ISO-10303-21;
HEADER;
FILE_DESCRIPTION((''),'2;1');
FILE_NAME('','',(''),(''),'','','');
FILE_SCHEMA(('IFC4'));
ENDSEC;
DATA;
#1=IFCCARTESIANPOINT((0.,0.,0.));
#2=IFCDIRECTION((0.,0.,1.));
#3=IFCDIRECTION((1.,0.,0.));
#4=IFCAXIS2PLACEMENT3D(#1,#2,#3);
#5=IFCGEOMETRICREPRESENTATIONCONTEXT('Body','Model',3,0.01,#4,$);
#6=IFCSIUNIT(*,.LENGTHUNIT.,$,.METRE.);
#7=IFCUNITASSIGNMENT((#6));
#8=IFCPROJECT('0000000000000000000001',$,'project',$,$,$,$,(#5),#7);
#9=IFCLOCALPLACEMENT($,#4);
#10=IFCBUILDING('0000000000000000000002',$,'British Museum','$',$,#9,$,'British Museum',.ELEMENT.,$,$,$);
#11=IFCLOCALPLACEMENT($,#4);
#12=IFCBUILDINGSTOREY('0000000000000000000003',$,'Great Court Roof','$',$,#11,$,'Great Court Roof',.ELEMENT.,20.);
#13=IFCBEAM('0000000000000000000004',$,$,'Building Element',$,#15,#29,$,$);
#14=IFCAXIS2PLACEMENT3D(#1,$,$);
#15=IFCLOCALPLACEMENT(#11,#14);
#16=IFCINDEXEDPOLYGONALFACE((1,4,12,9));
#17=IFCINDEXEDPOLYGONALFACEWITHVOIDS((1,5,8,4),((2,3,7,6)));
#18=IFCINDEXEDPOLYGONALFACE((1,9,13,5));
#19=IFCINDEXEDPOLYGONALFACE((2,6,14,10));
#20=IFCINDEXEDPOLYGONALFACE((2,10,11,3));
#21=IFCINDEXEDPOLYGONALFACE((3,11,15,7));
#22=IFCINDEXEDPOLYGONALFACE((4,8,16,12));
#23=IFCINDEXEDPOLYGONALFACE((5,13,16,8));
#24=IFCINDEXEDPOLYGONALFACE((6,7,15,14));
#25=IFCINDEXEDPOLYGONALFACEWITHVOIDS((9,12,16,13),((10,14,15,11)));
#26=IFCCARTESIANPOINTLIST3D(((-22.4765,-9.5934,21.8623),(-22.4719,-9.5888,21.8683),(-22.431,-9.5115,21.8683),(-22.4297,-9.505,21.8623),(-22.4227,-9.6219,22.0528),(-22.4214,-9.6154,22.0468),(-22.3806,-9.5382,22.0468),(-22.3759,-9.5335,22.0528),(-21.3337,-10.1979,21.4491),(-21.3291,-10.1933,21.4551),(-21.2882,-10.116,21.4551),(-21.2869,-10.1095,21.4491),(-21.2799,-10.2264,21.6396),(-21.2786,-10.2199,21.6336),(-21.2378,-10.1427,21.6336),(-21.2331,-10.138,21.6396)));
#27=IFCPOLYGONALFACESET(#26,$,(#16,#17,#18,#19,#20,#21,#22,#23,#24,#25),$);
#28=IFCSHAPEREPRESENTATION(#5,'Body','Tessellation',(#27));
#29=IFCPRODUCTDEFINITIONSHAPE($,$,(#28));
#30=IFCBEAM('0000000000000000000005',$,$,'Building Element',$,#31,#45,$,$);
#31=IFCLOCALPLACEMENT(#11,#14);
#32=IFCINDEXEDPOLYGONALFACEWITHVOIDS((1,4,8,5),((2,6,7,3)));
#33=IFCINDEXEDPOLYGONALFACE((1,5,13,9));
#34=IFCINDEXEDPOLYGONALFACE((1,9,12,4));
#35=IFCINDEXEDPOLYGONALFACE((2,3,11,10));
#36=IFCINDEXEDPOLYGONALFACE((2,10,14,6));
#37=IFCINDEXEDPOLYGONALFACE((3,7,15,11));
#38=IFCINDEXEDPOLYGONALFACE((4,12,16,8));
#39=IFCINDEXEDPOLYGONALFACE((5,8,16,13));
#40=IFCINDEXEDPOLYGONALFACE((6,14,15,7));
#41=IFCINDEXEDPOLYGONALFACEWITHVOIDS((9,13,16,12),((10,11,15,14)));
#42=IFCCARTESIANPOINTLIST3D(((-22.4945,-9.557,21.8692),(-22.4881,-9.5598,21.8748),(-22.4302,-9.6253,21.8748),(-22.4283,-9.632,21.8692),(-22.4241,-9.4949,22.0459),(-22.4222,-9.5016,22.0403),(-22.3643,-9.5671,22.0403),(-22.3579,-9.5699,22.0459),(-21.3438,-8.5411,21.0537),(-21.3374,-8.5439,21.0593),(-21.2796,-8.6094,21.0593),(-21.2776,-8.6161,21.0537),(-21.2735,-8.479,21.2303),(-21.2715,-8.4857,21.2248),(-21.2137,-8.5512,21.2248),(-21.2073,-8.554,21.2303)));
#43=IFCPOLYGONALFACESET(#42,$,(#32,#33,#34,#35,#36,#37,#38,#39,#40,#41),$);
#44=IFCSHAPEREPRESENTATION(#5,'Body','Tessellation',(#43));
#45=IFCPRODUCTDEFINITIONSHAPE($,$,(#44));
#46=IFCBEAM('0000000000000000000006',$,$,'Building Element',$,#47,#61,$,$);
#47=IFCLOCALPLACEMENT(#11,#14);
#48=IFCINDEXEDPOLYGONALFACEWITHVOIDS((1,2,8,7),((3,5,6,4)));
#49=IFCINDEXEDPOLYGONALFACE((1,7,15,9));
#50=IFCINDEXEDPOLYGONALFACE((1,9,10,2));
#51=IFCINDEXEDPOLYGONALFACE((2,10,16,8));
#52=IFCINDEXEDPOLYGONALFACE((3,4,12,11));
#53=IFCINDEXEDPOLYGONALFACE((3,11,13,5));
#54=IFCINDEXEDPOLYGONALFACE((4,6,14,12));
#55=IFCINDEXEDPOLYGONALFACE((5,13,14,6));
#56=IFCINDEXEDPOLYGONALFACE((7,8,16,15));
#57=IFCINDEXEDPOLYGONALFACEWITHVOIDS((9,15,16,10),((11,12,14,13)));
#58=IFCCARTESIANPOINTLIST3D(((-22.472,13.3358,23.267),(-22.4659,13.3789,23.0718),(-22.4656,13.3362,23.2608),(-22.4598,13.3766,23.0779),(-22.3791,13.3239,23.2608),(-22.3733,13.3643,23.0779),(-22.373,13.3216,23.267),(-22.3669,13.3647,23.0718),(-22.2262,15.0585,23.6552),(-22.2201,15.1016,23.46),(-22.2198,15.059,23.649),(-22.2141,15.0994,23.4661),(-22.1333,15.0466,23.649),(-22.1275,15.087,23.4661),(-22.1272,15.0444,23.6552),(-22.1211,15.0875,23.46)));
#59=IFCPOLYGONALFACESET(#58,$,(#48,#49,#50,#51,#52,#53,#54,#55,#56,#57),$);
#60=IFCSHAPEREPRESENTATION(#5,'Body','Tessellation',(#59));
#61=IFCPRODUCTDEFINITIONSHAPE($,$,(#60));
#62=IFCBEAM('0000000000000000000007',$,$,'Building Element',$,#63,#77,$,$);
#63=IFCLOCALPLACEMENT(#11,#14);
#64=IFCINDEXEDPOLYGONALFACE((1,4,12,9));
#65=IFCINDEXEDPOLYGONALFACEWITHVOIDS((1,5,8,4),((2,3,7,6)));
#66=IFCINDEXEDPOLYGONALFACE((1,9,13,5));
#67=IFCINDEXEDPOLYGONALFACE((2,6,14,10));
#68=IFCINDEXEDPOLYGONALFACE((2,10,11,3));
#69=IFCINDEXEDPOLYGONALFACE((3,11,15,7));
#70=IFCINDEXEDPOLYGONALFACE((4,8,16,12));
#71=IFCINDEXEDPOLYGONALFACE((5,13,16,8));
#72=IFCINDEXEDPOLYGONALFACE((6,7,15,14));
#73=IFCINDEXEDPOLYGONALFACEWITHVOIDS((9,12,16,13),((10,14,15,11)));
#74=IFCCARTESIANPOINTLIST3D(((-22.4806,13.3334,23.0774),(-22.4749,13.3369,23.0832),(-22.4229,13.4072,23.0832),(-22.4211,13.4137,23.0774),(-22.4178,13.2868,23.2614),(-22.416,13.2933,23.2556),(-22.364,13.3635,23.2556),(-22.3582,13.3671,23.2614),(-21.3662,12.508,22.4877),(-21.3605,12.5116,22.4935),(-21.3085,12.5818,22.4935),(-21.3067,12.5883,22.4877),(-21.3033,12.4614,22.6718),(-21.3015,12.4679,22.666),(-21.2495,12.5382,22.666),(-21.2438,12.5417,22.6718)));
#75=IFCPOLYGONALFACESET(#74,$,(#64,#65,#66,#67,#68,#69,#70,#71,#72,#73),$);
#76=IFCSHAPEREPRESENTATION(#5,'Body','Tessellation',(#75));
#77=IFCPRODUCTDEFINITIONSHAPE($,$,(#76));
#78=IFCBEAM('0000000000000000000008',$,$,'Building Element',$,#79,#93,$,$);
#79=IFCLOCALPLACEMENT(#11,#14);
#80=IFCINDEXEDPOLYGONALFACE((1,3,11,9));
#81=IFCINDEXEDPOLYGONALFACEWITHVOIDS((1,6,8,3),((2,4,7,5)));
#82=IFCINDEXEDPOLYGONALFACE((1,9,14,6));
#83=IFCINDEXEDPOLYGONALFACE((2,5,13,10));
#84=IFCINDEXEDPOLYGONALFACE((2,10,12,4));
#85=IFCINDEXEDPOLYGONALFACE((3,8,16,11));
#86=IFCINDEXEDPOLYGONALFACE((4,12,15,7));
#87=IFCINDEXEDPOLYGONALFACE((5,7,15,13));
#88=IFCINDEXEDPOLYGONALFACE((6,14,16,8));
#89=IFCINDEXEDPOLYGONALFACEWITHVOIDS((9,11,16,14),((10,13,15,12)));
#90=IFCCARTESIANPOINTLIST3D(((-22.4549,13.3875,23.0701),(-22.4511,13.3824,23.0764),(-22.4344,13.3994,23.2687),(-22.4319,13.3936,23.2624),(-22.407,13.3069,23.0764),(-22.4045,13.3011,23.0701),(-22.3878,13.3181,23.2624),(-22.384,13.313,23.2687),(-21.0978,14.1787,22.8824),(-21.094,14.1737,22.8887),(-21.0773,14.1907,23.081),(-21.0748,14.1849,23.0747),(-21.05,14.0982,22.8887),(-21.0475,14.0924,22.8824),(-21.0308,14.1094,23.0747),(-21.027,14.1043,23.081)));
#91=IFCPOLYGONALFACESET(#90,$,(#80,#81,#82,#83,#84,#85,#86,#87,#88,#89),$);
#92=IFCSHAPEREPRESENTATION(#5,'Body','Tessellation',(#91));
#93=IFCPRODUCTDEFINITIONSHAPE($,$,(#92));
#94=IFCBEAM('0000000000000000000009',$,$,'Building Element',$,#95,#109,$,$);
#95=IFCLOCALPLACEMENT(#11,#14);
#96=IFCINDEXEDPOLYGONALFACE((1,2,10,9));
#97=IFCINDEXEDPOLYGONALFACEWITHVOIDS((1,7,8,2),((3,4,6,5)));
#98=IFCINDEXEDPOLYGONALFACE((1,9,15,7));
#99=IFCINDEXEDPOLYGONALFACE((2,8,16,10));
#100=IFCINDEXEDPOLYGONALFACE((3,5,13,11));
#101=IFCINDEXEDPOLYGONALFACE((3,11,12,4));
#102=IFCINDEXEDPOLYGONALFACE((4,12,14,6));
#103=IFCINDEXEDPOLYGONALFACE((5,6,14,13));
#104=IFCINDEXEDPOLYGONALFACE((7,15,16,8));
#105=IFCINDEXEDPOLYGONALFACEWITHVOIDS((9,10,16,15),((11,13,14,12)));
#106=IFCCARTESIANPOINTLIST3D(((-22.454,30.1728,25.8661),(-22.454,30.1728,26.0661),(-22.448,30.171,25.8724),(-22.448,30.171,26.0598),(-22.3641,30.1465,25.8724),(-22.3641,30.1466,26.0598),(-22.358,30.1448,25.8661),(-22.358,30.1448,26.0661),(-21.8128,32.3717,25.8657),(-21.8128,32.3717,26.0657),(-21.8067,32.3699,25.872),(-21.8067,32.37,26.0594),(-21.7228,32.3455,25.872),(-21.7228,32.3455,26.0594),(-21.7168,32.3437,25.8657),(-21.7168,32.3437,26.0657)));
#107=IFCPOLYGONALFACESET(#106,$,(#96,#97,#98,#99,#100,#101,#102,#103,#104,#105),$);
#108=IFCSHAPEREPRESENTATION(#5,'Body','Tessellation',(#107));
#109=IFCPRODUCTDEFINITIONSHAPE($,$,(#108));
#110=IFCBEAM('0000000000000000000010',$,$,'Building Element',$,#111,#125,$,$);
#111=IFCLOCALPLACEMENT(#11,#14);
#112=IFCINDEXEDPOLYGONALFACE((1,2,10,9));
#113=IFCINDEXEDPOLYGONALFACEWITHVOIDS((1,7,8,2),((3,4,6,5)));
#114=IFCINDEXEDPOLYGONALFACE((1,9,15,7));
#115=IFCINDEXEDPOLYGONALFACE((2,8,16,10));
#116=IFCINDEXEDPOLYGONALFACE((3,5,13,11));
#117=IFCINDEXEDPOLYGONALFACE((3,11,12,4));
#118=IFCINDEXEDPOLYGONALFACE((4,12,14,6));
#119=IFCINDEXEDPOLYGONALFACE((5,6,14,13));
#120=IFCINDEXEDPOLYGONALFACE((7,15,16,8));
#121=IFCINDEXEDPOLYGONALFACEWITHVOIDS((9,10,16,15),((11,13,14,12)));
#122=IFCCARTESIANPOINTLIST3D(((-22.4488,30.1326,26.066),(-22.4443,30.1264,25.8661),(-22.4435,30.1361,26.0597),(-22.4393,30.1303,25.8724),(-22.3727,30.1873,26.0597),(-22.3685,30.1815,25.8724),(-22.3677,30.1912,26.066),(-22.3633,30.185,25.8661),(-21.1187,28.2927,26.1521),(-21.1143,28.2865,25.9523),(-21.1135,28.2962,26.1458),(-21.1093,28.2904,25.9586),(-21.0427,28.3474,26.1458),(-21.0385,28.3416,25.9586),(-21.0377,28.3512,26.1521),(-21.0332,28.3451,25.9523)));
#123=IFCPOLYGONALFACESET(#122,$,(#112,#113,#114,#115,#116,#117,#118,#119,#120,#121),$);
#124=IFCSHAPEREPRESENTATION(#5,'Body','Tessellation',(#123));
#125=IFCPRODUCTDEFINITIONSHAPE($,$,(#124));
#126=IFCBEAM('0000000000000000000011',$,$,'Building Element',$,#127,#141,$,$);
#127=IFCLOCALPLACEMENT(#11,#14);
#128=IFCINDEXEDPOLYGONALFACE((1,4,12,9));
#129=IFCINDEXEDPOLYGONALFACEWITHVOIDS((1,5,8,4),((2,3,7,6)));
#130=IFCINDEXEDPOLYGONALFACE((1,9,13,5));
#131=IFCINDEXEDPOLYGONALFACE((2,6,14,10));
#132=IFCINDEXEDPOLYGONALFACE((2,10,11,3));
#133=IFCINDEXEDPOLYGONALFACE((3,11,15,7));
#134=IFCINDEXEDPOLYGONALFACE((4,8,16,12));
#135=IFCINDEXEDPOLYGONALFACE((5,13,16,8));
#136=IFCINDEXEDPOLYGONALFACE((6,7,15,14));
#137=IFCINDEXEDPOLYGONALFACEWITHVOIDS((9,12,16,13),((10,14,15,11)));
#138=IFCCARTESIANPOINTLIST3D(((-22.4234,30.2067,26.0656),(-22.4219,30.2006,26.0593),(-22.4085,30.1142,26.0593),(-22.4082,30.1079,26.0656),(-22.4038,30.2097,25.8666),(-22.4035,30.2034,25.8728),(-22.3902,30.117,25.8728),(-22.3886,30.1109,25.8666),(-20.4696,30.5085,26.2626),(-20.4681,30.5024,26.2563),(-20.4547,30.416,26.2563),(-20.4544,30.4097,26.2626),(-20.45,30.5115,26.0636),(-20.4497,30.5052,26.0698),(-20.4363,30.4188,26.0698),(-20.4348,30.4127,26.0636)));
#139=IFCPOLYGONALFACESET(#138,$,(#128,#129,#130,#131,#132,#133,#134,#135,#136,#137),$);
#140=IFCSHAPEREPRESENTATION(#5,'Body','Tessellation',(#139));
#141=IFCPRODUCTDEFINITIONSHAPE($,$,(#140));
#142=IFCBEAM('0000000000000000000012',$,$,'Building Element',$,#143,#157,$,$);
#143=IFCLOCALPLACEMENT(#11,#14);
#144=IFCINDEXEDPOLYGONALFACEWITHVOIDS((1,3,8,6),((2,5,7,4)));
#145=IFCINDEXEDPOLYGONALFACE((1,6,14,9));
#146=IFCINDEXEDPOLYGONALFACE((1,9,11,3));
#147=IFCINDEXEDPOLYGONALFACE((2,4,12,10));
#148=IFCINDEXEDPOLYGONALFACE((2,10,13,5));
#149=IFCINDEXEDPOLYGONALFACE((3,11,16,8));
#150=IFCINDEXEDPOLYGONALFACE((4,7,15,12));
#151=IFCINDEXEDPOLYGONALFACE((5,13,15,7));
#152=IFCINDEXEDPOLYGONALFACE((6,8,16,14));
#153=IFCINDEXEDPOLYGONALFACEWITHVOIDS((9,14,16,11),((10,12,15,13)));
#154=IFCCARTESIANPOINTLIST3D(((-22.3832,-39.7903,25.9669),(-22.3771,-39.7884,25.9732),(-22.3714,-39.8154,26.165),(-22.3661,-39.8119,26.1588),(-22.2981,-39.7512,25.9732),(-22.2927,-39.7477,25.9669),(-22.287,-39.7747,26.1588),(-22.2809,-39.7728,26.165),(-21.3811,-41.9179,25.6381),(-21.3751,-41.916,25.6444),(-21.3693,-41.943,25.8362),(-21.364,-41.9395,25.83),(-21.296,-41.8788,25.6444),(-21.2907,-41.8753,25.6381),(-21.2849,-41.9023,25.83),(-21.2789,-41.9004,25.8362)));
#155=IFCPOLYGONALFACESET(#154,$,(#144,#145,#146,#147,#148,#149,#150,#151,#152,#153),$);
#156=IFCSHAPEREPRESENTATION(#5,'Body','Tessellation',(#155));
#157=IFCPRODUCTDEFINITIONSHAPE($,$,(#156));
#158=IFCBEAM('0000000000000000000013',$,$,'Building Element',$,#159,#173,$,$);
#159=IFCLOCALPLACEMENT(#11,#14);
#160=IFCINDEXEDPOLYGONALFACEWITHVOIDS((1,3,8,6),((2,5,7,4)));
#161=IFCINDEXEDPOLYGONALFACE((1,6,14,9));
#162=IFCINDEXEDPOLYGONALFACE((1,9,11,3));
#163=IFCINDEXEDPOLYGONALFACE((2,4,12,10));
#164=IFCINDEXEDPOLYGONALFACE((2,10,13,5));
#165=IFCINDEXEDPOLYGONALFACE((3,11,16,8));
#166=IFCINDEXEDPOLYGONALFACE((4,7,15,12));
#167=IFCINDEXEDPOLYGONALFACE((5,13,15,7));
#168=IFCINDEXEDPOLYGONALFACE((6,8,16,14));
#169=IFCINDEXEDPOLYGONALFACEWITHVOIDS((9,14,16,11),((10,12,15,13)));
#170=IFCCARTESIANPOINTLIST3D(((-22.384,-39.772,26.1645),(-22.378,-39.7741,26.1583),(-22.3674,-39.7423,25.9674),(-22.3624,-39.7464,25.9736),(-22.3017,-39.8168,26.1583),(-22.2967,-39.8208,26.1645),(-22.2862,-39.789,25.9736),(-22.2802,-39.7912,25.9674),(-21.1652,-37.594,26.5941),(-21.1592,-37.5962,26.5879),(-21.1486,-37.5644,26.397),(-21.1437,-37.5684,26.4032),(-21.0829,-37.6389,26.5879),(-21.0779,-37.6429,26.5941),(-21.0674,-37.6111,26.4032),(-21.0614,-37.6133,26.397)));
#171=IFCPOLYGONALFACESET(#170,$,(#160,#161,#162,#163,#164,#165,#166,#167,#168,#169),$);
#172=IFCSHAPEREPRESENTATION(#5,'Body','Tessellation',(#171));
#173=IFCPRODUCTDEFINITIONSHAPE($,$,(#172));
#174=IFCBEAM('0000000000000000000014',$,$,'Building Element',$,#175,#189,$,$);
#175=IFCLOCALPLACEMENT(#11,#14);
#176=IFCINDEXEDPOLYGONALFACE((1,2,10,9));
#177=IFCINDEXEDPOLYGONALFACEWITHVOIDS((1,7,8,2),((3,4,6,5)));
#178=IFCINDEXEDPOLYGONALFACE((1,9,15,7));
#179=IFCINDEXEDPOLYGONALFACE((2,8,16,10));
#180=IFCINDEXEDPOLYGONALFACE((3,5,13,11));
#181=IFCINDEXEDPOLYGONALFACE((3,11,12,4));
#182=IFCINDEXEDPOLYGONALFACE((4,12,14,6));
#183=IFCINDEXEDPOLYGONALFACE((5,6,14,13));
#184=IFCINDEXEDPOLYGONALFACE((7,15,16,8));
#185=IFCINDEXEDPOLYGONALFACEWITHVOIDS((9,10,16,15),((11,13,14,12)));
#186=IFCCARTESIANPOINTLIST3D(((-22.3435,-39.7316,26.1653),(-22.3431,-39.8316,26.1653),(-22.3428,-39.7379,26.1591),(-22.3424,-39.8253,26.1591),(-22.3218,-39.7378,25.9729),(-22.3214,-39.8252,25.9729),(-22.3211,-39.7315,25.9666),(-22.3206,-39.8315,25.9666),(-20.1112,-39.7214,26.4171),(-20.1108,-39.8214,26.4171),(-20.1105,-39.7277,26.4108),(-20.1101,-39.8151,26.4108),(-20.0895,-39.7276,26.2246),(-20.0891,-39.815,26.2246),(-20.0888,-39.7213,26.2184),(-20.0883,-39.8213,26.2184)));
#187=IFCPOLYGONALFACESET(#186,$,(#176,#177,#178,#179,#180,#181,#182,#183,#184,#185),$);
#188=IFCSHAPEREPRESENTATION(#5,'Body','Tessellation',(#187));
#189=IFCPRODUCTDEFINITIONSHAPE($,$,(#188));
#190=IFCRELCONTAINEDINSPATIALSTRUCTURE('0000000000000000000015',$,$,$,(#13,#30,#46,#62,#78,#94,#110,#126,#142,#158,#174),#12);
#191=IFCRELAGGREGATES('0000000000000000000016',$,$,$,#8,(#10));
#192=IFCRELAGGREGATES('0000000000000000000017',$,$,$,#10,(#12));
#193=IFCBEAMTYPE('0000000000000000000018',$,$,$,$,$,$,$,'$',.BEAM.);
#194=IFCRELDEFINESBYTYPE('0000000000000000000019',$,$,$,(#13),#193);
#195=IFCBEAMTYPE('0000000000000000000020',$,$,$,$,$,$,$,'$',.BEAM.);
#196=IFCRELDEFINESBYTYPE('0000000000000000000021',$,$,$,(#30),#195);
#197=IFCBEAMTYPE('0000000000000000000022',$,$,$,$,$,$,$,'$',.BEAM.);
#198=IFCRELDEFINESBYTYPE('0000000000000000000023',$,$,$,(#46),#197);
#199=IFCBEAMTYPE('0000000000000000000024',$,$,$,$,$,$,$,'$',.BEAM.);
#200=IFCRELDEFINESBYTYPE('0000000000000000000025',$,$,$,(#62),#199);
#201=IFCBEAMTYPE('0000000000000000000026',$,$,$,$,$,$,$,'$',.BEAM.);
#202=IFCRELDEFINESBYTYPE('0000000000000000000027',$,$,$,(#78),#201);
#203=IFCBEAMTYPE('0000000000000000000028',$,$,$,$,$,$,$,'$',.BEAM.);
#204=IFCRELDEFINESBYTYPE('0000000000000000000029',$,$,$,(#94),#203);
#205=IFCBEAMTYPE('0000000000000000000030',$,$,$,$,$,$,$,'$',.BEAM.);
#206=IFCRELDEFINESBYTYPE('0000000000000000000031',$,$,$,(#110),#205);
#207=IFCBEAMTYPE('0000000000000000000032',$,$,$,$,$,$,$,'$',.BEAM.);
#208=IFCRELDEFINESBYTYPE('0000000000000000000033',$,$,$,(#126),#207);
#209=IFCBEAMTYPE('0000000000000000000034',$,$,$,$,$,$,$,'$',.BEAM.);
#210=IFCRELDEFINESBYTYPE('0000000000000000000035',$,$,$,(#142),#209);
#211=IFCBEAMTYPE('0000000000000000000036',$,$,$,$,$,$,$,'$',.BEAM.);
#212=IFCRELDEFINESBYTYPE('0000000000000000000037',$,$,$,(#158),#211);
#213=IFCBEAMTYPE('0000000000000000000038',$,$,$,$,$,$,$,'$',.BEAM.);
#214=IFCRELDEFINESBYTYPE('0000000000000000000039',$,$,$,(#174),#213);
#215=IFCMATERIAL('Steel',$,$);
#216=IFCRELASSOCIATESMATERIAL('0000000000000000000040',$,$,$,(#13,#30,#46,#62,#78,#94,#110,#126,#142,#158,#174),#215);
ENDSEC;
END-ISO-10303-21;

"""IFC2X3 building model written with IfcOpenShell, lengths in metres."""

from ifc_helpers import new_model, si_unit, frame, origin_with_axes, origin_2d, place, context, project, spatial, hollow_rectangle, extrude, material, type_object, element, save


model = new_model("IFC2X3")

# Units and contexts
model_context = context("Model", 3, precision=0.01, world=origin_with_axes(), identifier="Body")
ifc_project = project(units=[si_unit("LENGTHUNIT", "METRE")], contexts=[model_context])

# Building, storey
building_placement = place(None, origin_with_axes())
building = spatial("IfcBuilding", under=ifc_project, at=building_placement, Name="British Museum", Description="$", LongName="British Museum", CompositionType="ELEMENT")
storey_placement = place(None, origin_with_axes())
storey = spatial("IfcBuildingStorey", under=building, at=storey_placement, Name="Great Court Roof", Description="$", LongName="Great Court Roof", CompositionType="ELEMENT", Elevation=20.0)

# Beams
ifc_material = material(Name="Steel")
beam_type_1 = type_object("IfcBeamType", ElementType="$", PredefinedType="BEAM")
beam_1_placement = place(None, origin_with_axes())
element("IfcBeam", 1, at=beam_1_placement, inside=storey, type_object=beam_type_1, material=ifc_material, Description="Building Element", context=model_context, shape_type="SweptSolid", body=[
    extrude(hollow_rectangle(XDim=0.1, YDim=0.2, WallThickness=0.0063, InnerFilletRadius=0.0, OuterFilletRadius=0.0, at=origin_2d()), frame((-22.4262, -9.5635, 21.9575), z_axis=(0.841988, -0.445377, -0.30446), x_axis=(0.467575, 0.883953, 0.0)), (0.0, 0.0, 1.0), 1.3573),
])
beam_type_2 = type_object("IfcBeamType", ElementType="$", PredefinedType="BEAM")
beam_2_placement = place(None, origin_with_axes())
element("IfcBeam", 2, at=beam_2_placement, inside=storey, type_object=beam_type_2, material=ifc_material, Description="Building Element", context=model_context, shape_type="SweptSolid", body=[
    extrude(hollow_rectangle(XDim=0.1, YDim=0.2, WallThickness=0.0063, InnerFilletRadius=0.0, OuterFilletRadius=0.0, at=origin_2d()), frame((-22.4262, -9.5635, 21.9575), z_axis=(0.662008, 0.584472, -0.469188), x_axis=(-0.661843, 0.749643, 0.0)), (0.0, 0.0, 1.0), 1.7382),
])
beam_type_3 = type_object("IfcBeamType", ElementType="$", PredefinedType="BEAM")
beam_3_placement = place(None, origin_with_axes())
element("IfcBeam", 3, at=beam_3_placement, inside=storey, type_object=beam_type_3, material=ifc_material, Description="Building Element", context=model_context, shape_type="SweptSolid", body=[
    extrude(hollow_rectangle(XDim=0.1, YDim=0.2, WallThickness=0.0063, InnerFilletRadius=0.0, OuterFilletRadius=0.0, at=origin_2d()), frame((-22.4194, 13.3502, 23.1694), z_axis=(0.137841, 0.966229, 0.217718), x_axis=(-0.989977, 0.141229, 0.0)), (0.0, 0.0, 1.0), 1.783),
])
beam_type_4 = type_object("IfcBeamType", ElementType="$", PredefinedType="BEAM")
beam_4_placement = place(None, origin_with_axes())
element("IfcBeam", 4, at=beam_4_placement, inside=storey, type_object=beam_type_4, material=ifc_material, Description="Building Element", context=model_context, shape_type="SweptSolid", body=[
    extrude(hollow_rectangle(XDim=0.1, YDim=0.2, WallThickness=0.0063, InnerFilletRadius=0.0, OuterFilletRadius=0.0, at=origin_2d()), frame((-22.4194, 13.3502, 23.1694), z_axis=(0.739528, -0.547718, -0.391283), x_axis=(0.595171, 0.803599, 0.0)), (0.0, 0.0, 1.0), 1.507),
])
beam_type_5 = type_object("IfcBeamType", ElementType="$", PredefinedType="BEAM")
beam_5_placement = place(None, origin_with_axes())
element("IfcBeam", 5, at=beam_5_placement, inside=storey, type_object=beam_type_5, material=ifc_material, Description="Building Element", context=model_context, shape_type="SweptSolid", body=[
    extrude(hollow_rectangle(XDim=0.1, YDim=0.2, WallThickness=0.0063, InnerFilletRadius=0.0, OuterFilletRadius=0.0, at=origin_2d()), frame((-22.4194, 13.3502, 23.1694), z_axis=(0.857767, 0.50016, -0.118642), x_axis=(-0.503717, 0.863868, 0.0)), (0.0, 0.0, 1.0), 1.5821),
])
beam_type_6 = type_object("IfcBeamType", ElementType="$", PredefinedType="BEAM")
beam_6_placement = place(None, origin_with_axes())
element("IfcBeam", 6, at=beam_6_placement, inside=storey, type_object=beam_type_6, material=ifc_material, Description="Building Element", context=model_context, shape_type="SweptSolid", body=[
    extrude(hollow_rectangle(XDim=0.1, YDim=0.2, WallThickness=0.0063, InnerFilletRadius=0.0, OuterFilletRadius=0.0, at=origin_2d()), frame((-22.406, 30.1588, 25.9661), z_axis=(0.279953, 0.960014, -0.000157), x_axis=(-0.960014, 0.279953, 0.0)), (0.0, 0.0, 1.0), 2.2905),
])
beam_type_7 = type_object("IfcBeamType", ElementType="$", PredefinedType="BEAM")
beam_7_placement = place(None, origin_with_axes())
element("IfcBeam", 7, at=beam_7_placement, inside=storey, type_object=beam_type_7, material=ifc_material, Description="Building Element", context=model_context, shape_type="SweptSolid", body=[
    extrude(hollow_rectangle(XDim=0.1, YDim=0.2, WallThickness=0.0063, InnerFilletRadius=0.0, OuterFilletRadius=0.0, at=origin_2d()), frame((-22.406, 30.1588, 25.9661), z_axis=(0.585416, -0.809846, 0.03791), x_axis=(0.810429, 0.585837, 0.0)), (0.0, 0.0, 1.0), 2.2719),
])
beam_type_8 = type_object("IfcBeamType", ElementType="$", PredefinedType="BEAM")
beam_8_placement = place(None, origin_with_axes())
element("IfcBeam", 8, at=beam_8_placement, inside=storey, type_object=beam_type_8, material=ifc_material, Description="Building Element", context=model_context, shape_type="SweptSolid", body=[
    extrude(hollow_rectangle(XDim=0.1, YDim=0.2, WallThickness=0.0063, InnerFilletRadius=0.0, OuterFilletRadius=0.0, at=origin_2d()), frame((-22.406, 30.1588, 25.9661), z_axis=(0.983409, 0.151907, 0.099151), x_axis=(-0.15266, 0.988279, 0.0)), (0.0, 0.0, 1.0), 1.9868),
])
beam_type_9 = type_object("IfcBeamType", ElementType="$", PredefinedType="BEAM")
beam_9_placement = place(None, origin_with_axes())
element("IfcBeam", 9, at=beam_9_placement, inside=storey, type_object=beam_type_9, material=ifc_material, Description="Building Element", context=model_context, shape_type="SweptSolid", body=[
    extrude(hollow_rectangle(XDim=0.1, YDim=0.2, WallThickness=0.0063, InnerFilletRadius=0.0, OuterFilletRadius=0.0, at=origin_2d()), frame((-22.3321, -39.7816, 26.066), z_axis=(0.421988, -0.895965, -0.138466), x_axis=(0.90468, 0.426093, 0.0)), (0.0, 0.0, 1.0), 2.3746),
])
beam_type_10 = type_object("IfcBeamType", ElementType="$", PredefinedType="BEAM")
beam_10_placement = place(None, origin_with_axes())
element("IfcBeam", 10, at=beam_10_placement, inside=storey, type_object=beam_type_10, material=ifc_material, Description="Building Element", context=model_context, shape_type="SweptSolid", body=[
    extrude(hollow_rectangle(XDim=0.1, YDim=0.2, WallThickness=0.0063, InnerFilletRadius=0.0, OuterFilletRadius=0.0, at=origin_2d()), frame((-22.3321, -39.7816, 26.066), z_axis=(0.48127, 0.860004, 0.169627), x_axis=(-0.87265, 0.488346, 0.0)), (0.0, 0.0, 1.0), 2.5325),
])
beam_type_11 = type_object("IfcBeamType", ElementType="$", PredefinedType="BEAM")
beam_11_placement = place(None, origin_with_axes())
element("IfcBeam", 11, at=beam_11_placement, inside=storey, type_object=beam_type_11, material=ifc_material, Description="Building Element", context=model_context, shape_type="SweptSolid", body=[
    extrude(hollow_rectangle(XDim=0.1, YDim=0.2, WallThickness=0.0063, InnerFilletRadius=0.0, OuterFilletRadius=0.0, at=origin_2d()), frame((-22.3321, -39.7816, 26.066), z_axis=(0.99369, 0.004539, 0.11207), x_axis=(-0.004568, 0.99999, 0.0)), (0.0, 0.0, 1.0), 2.2465),
])

save(model, "model.ifc")
